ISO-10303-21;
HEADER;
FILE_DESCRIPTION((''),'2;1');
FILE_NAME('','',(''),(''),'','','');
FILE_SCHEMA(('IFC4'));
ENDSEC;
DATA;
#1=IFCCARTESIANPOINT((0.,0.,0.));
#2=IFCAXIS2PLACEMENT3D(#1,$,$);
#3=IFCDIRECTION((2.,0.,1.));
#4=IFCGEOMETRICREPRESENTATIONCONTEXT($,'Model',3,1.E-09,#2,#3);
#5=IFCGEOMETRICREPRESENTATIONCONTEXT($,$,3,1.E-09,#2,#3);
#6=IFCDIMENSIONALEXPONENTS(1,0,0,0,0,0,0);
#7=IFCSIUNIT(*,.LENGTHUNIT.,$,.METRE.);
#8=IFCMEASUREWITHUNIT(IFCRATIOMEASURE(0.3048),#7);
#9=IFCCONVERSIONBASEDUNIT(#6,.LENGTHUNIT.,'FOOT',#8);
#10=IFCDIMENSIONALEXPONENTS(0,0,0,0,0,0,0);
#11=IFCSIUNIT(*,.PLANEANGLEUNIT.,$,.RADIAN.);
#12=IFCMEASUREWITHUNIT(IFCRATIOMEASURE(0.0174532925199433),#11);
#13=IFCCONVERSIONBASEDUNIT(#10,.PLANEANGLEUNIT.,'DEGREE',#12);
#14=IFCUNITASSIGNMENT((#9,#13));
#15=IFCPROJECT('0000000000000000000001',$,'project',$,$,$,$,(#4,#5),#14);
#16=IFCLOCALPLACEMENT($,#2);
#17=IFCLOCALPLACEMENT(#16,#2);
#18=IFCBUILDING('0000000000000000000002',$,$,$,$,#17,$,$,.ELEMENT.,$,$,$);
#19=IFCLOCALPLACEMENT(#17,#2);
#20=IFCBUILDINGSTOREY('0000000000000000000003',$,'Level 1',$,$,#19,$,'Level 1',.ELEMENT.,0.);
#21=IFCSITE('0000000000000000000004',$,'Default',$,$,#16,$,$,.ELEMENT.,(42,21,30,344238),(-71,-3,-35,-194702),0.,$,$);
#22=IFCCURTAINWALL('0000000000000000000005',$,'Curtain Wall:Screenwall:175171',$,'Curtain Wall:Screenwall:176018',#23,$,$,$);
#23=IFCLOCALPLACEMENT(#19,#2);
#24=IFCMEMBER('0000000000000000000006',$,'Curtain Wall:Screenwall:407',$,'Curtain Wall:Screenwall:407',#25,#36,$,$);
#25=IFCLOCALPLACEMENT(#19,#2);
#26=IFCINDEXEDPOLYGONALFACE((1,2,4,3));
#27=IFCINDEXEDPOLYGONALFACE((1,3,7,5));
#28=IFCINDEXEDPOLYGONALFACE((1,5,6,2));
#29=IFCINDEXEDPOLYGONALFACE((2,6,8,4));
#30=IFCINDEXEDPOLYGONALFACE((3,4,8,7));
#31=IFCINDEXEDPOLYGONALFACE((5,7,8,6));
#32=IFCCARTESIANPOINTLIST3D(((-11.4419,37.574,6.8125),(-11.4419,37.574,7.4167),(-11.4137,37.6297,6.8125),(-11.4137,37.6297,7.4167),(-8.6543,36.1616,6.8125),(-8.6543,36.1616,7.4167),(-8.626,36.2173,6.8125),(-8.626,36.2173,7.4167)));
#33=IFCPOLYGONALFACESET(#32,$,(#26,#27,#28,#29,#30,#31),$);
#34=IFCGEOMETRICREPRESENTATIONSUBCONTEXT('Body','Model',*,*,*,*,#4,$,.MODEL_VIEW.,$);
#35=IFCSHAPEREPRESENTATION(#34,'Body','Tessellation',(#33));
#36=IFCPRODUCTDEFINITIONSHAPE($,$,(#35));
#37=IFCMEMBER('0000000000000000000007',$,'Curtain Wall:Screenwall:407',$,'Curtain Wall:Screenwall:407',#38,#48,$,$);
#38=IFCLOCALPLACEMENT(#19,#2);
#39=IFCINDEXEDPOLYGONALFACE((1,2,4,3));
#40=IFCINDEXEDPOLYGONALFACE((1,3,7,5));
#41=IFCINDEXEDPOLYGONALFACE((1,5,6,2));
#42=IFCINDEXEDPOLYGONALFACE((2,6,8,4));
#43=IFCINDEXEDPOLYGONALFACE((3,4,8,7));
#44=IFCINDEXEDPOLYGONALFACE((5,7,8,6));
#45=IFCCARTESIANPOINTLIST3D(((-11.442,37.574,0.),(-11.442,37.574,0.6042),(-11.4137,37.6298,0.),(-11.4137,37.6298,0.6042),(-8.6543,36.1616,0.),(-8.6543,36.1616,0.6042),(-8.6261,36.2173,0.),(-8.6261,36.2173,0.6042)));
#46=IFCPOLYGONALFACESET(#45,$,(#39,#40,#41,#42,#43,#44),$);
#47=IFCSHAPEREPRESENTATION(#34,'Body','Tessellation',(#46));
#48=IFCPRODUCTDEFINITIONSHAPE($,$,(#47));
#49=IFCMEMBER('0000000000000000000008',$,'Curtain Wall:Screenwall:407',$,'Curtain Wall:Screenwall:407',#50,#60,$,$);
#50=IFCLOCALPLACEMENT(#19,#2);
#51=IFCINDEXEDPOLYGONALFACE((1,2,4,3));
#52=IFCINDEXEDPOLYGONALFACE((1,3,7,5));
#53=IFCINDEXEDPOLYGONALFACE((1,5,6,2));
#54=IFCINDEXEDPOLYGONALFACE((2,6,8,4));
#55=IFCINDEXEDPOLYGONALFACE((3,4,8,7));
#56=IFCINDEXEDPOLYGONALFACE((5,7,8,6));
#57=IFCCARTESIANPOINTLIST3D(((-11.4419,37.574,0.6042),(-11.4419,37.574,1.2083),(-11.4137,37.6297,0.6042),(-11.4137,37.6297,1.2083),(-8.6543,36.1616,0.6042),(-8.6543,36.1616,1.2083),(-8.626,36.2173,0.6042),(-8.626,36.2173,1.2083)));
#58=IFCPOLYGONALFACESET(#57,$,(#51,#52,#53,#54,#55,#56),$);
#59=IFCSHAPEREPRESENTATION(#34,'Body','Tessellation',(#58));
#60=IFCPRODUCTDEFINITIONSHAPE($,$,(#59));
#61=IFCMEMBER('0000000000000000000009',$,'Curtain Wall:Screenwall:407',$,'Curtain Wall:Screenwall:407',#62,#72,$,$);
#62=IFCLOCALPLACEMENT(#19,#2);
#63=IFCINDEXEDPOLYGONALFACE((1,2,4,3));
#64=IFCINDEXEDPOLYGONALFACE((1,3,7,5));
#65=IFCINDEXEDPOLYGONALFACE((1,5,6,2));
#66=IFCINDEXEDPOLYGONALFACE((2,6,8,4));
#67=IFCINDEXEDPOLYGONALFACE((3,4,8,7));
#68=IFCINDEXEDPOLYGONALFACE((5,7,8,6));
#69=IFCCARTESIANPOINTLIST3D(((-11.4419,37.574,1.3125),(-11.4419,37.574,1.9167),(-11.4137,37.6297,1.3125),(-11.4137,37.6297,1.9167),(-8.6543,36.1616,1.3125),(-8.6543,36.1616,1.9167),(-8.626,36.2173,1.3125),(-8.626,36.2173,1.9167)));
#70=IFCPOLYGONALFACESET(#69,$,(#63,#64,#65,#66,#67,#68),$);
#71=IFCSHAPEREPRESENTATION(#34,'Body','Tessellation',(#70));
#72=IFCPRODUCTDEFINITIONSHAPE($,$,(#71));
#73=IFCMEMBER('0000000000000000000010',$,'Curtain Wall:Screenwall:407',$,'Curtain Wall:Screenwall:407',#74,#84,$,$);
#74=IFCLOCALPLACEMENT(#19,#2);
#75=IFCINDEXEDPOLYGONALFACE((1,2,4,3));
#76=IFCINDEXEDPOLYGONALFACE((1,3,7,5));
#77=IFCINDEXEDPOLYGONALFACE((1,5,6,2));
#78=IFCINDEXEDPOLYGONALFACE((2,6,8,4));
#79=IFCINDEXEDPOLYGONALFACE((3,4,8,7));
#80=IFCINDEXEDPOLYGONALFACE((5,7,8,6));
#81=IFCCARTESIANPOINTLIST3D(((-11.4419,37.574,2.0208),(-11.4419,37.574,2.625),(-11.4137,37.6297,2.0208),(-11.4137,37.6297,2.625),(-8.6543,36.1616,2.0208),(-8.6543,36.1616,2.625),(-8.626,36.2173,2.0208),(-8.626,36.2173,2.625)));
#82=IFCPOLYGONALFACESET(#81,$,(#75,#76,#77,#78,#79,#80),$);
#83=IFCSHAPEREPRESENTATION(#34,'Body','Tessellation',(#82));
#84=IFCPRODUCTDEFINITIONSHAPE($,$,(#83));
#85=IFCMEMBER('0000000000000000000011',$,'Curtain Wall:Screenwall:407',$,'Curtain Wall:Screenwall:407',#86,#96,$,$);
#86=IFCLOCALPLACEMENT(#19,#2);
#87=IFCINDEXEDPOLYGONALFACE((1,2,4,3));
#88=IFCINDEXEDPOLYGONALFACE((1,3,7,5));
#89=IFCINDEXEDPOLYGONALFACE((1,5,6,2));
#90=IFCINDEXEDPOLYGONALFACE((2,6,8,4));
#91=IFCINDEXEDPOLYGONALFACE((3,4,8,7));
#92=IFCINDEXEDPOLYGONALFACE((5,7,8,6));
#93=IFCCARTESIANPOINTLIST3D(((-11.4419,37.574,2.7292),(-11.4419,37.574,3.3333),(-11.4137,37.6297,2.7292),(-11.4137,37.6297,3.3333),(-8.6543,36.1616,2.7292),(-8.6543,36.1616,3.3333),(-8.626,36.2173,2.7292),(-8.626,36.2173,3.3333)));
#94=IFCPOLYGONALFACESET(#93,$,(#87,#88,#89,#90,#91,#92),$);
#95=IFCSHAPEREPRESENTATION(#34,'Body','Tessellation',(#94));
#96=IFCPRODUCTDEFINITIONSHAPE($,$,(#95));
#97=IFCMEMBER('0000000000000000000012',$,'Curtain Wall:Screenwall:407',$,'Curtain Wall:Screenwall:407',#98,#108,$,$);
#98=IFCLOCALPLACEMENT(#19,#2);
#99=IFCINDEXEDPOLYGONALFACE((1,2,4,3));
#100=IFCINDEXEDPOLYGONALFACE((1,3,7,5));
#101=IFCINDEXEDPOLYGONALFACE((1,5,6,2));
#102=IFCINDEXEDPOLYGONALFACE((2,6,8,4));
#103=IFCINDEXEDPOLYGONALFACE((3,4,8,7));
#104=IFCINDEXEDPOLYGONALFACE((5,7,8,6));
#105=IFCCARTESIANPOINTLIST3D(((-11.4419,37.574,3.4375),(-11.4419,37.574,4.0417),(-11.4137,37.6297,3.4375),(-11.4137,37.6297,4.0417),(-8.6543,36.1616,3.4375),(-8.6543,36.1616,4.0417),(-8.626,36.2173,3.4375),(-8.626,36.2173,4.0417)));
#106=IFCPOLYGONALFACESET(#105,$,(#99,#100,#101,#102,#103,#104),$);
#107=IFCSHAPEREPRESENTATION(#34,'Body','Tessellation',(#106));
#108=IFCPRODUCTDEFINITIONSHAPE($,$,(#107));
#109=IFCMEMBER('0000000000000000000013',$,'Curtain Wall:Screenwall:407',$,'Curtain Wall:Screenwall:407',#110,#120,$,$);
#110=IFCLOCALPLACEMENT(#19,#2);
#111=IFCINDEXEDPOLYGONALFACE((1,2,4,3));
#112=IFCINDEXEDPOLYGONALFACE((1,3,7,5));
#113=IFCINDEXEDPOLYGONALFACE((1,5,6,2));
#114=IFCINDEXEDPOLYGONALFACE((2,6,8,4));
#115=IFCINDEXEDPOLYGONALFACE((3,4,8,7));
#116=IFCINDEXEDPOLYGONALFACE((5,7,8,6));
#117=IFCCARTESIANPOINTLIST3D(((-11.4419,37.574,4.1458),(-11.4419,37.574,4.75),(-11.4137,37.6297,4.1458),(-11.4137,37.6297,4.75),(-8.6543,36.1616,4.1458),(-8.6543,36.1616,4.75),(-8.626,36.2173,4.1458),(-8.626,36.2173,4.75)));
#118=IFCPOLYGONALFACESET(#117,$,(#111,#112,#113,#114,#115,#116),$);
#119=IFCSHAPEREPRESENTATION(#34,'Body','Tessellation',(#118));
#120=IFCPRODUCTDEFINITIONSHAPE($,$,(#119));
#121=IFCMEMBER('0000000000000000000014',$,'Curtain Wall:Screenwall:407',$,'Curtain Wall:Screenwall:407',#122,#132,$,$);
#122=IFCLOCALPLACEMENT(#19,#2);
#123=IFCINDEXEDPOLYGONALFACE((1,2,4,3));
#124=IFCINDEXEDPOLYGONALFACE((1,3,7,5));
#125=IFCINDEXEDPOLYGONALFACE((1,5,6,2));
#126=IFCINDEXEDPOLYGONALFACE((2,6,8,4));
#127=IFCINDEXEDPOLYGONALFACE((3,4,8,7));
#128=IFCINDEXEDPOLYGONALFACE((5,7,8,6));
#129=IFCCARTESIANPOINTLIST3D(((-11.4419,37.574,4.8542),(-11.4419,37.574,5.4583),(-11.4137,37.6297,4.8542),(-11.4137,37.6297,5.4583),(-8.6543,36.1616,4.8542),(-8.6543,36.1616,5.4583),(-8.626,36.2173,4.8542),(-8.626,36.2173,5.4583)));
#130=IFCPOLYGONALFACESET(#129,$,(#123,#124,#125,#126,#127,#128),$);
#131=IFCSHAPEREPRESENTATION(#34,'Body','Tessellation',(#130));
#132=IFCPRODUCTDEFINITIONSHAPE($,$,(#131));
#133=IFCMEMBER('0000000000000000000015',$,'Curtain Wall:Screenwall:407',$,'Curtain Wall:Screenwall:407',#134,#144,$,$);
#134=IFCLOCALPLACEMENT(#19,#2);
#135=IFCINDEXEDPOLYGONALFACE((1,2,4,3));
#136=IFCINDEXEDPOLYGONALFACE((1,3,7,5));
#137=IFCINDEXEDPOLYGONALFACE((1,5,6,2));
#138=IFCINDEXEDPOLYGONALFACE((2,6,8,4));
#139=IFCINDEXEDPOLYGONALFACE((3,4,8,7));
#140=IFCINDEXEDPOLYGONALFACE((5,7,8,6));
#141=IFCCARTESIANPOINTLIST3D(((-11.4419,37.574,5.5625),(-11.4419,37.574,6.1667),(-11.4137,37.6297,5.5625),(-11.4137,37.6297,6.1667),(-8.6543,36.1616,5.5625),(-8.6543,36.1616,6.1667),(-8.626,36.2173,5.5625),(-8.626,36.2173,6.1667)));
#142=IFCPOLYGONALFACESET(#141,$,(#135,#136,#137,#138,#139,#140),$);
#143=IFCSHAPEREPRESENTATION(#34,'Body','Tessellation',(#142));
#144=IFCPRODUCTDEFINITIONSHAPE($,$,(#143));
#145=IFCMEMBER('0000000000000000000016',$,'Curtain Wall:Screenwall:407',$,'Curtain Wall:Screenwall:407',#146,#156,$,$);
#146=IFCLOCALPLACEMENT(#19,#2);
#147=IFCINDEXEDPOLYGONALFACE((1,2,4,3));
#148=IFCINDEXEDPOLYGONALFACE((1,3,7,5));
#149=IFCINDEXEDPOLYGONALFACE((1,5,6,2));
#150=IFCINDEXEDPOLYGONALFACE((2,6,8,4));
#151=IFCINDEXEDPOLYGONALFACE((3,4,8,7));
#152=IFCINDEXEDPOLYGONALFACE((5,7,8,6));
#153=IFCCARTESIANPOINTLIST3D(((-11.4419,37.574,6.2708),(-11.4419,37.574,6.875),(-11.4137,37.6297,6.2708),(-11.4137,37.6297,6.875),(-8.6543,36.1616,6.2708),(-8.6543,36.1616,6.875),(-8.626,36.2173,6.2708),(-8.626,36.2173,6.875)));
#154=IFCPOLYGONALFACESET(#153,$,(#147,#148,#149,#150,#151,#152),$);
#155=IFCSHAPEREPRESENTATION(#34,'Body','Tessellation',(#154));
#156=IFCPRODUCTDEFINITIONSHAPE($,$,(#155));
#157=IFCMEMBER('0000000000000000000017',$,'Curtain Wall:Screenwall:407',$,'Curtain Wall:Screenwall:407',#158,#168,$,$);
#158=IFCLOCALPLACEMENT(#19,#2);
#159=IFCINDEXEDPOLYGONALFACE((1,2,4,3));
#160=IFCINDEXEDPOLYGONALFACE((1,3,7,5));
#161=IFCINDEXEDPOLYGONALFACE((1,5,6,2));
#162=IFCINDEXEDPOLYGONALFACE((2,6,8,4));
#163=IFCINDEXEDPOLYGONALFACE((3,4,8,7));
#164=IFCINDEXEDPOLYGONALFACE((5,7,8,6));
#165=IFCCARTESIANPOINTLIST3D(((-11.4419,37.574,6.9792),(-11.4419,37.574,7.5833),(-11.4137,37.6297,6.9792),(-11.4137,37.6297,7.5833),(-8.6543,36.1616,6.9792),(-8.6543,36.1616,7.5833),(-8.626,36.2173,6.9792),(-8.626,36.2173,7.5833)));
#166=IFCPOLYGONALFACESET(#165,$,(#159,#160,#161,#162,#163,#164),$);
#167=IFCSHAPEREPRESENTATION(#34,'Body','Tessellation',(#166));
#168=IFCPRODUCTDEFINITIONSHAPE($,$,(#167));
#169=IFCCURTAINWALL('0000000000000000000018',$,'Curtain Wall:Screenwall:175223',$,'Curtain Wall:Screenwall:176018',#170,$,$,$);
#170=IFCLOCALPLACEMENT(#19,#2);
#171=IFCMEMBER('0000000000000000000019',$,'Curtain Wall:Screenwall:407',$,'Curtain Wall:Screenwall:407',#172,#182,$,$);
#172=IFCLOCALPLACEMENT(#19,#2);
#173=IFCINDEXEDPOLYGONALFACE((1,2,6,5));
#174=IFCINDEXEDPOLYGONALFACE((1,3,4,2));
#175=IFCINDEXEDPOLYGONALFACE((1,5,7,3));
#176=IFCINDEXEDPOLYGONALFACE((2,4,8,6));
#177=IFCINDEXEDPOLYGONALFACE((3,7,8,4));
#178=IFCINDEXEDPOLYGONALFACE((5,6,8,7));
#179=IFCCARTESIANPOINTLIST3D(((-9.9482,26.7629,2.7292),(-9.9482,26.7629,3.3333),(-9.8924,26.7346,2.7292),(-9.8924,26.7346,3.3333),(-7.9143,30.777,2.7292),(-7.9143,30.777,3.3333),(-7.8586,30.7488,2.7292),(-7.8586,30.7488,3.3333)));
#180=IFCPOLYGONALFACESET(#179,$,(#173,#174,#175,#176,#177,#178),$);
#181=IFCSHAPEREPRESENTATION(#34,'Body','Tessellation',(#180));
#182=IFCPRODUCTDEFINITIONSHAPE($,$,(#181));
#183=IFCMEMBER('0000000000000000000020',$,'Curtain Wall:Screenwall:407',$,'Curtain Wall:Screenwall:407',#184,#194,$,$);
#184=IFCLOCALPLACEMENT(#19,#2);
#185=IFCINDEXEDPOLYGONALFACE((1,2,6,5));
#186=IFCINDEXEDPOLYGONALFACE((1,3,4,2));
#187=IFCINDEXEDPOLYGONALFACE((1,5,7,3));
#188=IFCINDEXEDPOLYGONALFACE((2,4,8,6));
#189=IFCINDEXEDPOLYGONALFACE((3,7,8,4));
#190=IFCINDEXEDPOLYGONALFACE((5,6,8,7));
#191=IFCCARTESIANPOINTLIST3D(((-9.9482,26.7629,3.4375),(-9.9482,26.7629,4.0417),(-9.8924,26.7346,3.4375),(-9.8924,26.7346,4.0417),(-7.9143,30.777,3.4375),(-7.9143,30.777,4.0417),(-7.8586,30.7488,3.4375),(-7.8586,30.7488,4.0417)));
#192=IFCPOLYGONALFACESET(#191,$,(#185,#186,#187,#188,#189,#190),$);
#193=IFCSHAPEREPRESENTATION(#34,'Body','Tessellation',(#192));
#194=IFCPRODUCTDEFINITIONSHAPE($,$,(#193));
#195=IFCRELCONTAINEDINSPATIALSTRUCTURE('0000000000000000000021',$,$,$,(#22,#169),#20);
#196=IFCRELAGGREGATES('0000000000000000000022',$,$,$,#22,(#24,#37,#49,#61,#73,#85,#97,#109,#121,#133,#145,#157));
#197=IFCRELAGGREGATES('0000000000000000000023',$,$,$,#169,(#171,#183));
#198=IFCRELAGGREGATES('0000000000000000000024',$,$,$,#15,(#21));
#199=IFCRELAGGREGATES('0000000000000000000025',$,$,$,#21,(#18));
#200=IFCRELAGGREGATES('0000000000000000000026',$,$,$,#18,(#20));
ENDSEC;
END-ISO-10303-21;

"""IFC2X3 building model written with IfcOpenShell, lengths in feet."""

from ifc_helpers import new_model, entity, si_unit, converted_unit, direction, frame, frame_2d, origin, origin_2d_with_axis, place, context, subcontext, project, spatial, rectangle, extrude, element, aggregate, save


model = new_model("IFC2X3")

# Units and contexts
model_context = context("Model", 3, precision=1e-09, world=origin(), true_north=direction((2.0, 0.0, 1.0)))
context_of_model = context(None, 3, precision=1e-09, world=origin(), true_north=direction((2.0, 0.0, 1.0)))
body_context = subcontext(model_context, "Body", "Model", "MODEL_VIEW")
ifc_project = project(units=[converted_unit("LENGTHUNIT", "FOOT", entity("IfcRatioMeasure", 0.3048), si_unit("LENGTHUNIT", "METRE"), dimensions=[1, 0, 0, 0, 0, 0, 0]), converted_unit("PLANEANGLEUNIT", "DEGREE", entity("IfcRatioMeasure", 0.0174532925199433), si_unit("PLANEANGLEUNIT", "RADIAN"), dimensions=[0, 0, 0, 0, 0, 0, 0])], contexts=[model_context, context_of_model])

# Site, building, storey
site_placement = place(None, origin())
site = spatial("IfcSite", under=ifc_project, at=site_placement, Name="Default", CompositionType="ELEMENT", RefLatitude=(42, 21, 30, 344238), RefLongitude=(-71, -3, -35, -194702), RefElevation=0.0)
building_placement = place(site_placement, origin())
building = spatial("IfcBuilding", under=site, at=building_placement, CompositionType="ELEMENT")
storey_placement = place(building_placement, origin())
storey = spatial("IfcBuildingStorey", under=building, at=storey_placement, Name="Level 1", LongName="Level 1", CompositionType="ELEMENT", Elevation=0.0)

# Curtain walls, members
curtain_wall_1_placement = place(storey_placement, origin())
curtain_wall_1 = element("IfcCurtainWall", 1, at=curtain_wall_1_placement, inside=storey, Name="Curtain Wall:Screenwall:175171", ObjectType="Curtain Wall:Screenwall:176018")
member_1_placement = place(curtain_wall_1_placement, frame((-11.4419, 36.1616, 6.8125)))
member_1 = element("IfcMember", 2, at=member_1_placement, Name="Curtain Wall:Screenwall:407", ObjectType="Curtain Wall:Screenwall:407", context=body_context, shape_type="SweptSolid", body=[
    extrude(rectangle(XDim=3.1251, YDim=0.0625, at=frame_2d((0.0, 0.0), x_axis=(1.0, 0.0))), frame((1.408, 0.7341, 0.0), z_axis=(0.0, 0.0, 1.0), x_axis=(0.892034, -0.451968, 0.0)), (0.0, 0.0, 1.0), 0.6042),
])
member_2_placement = place(curtain_wall_1_placement, frame((-11.442, 36.1616, 0.0)))
member_2 = element("IfcMember", 3, at=member_2_placement, Name="Curtain Wall:Screenwall:407", ObjectType="Curtain Wall:Screenwall:407", context=body_context, shape_type="SweptSolid", body=[
    extrude(rectangle(XDim=3.1251, YDim=0.0625, at=frame_2d((0.0, 0.0), x_axis=(1.0, 0.0))), frame((1.408, 0.7341, 0.0), z_axis=(0.0, 0.0, 1.0), x_axis=(-0.892034, 0.451968, 0.0)), (0.0, 0.0, 1.0), 0.6042),
])
member_3_placement = place(curtain_wall_1_placement, frame((-11.4419, 36.1616, 0.6042)))
member_3 = element("IfcMember", 4, at=member_3_placement, Name="Curtain Wall:Screenwall:407", ObjectType="Curtain Wall:Screenwall:407", context=body_context, shape_type="SweptSolid", body=[
    extrude(rectangle(XDim=3.1251, YDim=0.0625, at=frame_2d((0.0, 0.0), x_axis=(1.0, 0.0))), frame((1.408, 0.7341, 0.0), z_axis=(0.0, 0.0, 1.0), x_axis=(0.892034, -0.451968, 0.0)), (0.0, 0.0, 1.0), 0.6042),
])
member_4_placement = place(curtain_wall_1_placement, frame((-11.4419, 36.1616, 1.3125)))
member_4 = element("IfcMember", 5, at=member_4_placement, Name="Curtain Wall:Screenwall:407", ObjectType="Curtain Wall:Screenwall:407", context=body_context, shape_type="SweptSolid", body=[
    extrude(rectangle(XDim=3.1251, YDim=0.0625, at=frame_2d((0.0, 0.0), x_axis=(1.0, 0.0))), frame((1.408, 0.7341, 0.0), z_axis=(0.0, 0.0, 1.0), x_axis=(0.892034, -0.451968, 0.0)), (0.0, 0.0, 1.0), 0.6042),
])
member_5_placement = place(curtain_wall_1_placement, frame((-11.4419, 36.1616, 2.0208)))
member_5 = element("IfcMember", 6, at=member_5_placement, Name="Curtain Wall:Screenwall:407", ObjectType="Curtain Wall:Screenwall:407", context=body_context, shape_type="SweptSolid", body=[
    extrude(rectangle(XDim=3.1251, YDim=0.0625, at=frame_2d((0.0, 0.0), x_axis=(1.0, 0.0))), frame((1.408, 0.7341, 0.0), z_axis=(0.0, 0.0, 1.0), x_axis=(0.892034, -0.451968, 0.0)), (0.0, 0.0, 1.0), 0.6042),
])
member_6_placement = place(curtain_wall_1_placement, frame((-11.4419, 36.1616, 2.7292)))
member_6 = element("IfcMember", 7, at=member_6_placement, Name="Curtain Wall:Screenwall:407", ObjectType="Curtain Wall:Screenwall:407", context=body_context, shape_type="SweptSolid", body=[
    extrude(rectangle(XDim=3.1251, YDim=0.0625, at=frame_2d((0.0, 0.0), x_axis=(1.0, 0.0))), frame((1.408, 0.7341, 0.0), z_axis=(0.0, 0.0, 1.0), x_axis=(0.892034, -0.451968, 0.0)), (0.0, 0.0, 1.0), 0.6042),
])
member_7_placement = place(curtain_wall_1_placement, frame((-11.4419, 36.1616, 3.4375)))
member_7 = element("IfcMember", 8, at=member_7_placement, Name="Curtain Wall:Screenwall:407", ObjectType="Curtain Wall:Screenwall:407", context=body_context, shape_type="SweptSolid", body=[
    extrude(rectangle(XDim=3.1251, YDim=0.0625, at=frame_2d((0.0, 0.0), x_axis=(1.0, 0.0))), frame((1.408, 0.7341, 0.0), z_axis=(0.0, 0.0, 1.0), x_axis=(0.892034, -0.451968, 0.0)), (0.0, 0.0, 1.0), 0.6042),
])
member_8_placement = place(curtain_wall_1_placement, frame((-11.4419, 36.1616, 4.1458)))
member_8 = element("IfcMember", 9, at=member_8_placement, Name="Curtain Wall:Screenwall:407", ObjectType="Curtain Wall:Screenwall:407", context=body_context, shape_type="SweptSolid", body=[
    extrude(rectangle(XDim=3.1251, YDim=0.0625, at=frame_2d((0.0, 0.0), x_axis=(1.0, 0.0))), frame((1.408, 0.7341, 0.0), z_axis=(0.0, 0.0, 1.0), x_axis=(0.892034, -0.451968, 0.0)), (0.0, 0.0, 1.0), 0.6042),
])
member_9_placement = place(curtain_wall_1_placement, frame((-11.4419, 36.1616, 4.8542)))
member_9 = element("IfcMember", 10, at=member_9_placement, Name="Curtain Wall:Screenwall:407", ObjectType="Curtain Wall:Screenwall:407", context=body_context, shape_type="SweptSolid", body=[
    extrude(rectangle(XDim=3.1251, YDim=0.0625, at=frame_2d((0.0, 0.0), x_axis=(1.0, 0.0))), frame((1.408, 0.7341, 0.0), z_axis=(0.0, 0.0, 1.0), x_axis=(0.892034, -0.451968, 0.0)), (0.0, 0.0, 1.0), 0.6042),
])
member_10_placement = place(curtain_wall_1_placement, frame((-11.4419, 36.1616, 5.5625)))
member_10 = element("IfcMember", 11, at=member_10_placement, Name="Curtain Wall:Screenwall:407", ObjectType="Curtain Wall:Screenwall:407", context=body_context, shape_type="SweptSolid", body=[
    extrude(rectangle(XDim=3.1251, YDim=0.0625, at=frame_2d((0.0, 0.0), x_axis=(1.0, 0.0))), frame((1.408, 0.7341, 0.0), z_axis=(0.0, 0.0, 1.0), x_axis=(0.892034, -0.451968, 0.0)), (0.0, 0.0, 1.0), 0.6042),
])
member_11_placement = place(curtain_wall_1_placement, frame((-11.4419, 36.1616, 6.2708)))
member_11 = element("IfcMember", 12, at=member_11_placement, Name="Curtain Wall:Screenwall:407", ObjectType="Curtain Wall:Screenwall:407", context=body_context, shape_type="SweptSolid", body=[
    extrude(rectangle(XDim=3.1251, YDim=0.0625, at=frame_2d((0.0, 0.0), x_axis=(1.0, 0.0))), frame((1.408, 0.7341, 0.0), z_axis=(0.0, 0.0, 1.0), x_axis=(0.892034, -0.451968, 0.0)), (0.0, 0.0, 1.0), 0.6042),
])
member_12_placement = place(curtain_wall_1_placement, frame((-11.4419, 36.1616, 6.9792)))
member_12 = element("IfcMember", 13, at=member_12_placement, Name="Curtain Wall:Screenwall:407", ObjectType="Curtain Wall:Screenwall:407", context=body_context, shape_type="SweptSolid", body=[
    extrude(rectangle(XDim=3.1251, YDim=0.0625, at=frame_2d((0.0, 0.0), x_axis=(1.0, 0.0))), frame((1.408, 0.7341, 0.0), z_axis=(0.0, 0.0, 1.0), x_axis=(0.892034, -0.451968, 0.0)), (0.0, 0.0, 1.0), 0.6042),
])
aggregate(curtain_wall_1, [member_1, member_2, member_3, member_4, member_5, member_6, member_7, member_8, member_9, member_10, member_11, member_12])
curtain_wall_2_placement = place(storey_placement, origin())
curtain_wall_2 = element("IfcCurtainWall", 14, at=curtain_wall_2_placement, inside=storey, Name="Curtain Wall:Screenwall:175223", ObjectType="Curtain Wall:Screenwall:176018")
member_13_placement = place(curtain_wall_2_placement, frame((-9.9482, 26.7346, 2.7292)))
member_13 = element("IfcMember", 15, at=member_13_placement, Name="Curtain Wall:Screenwall:407", ObjectType="Curtain Wall:Screenwall:407", context=body_context, shape_type="SweptSolid", body=[
    extrude(rectangle(XDim=4.5, YDim=0.0625, at=origin_2d_with_axis()), frame((1.0448, 2.0212, 0.0), z_axis=(0.0, 0.0, 1.0), x_axis=(-0.451968, -0.892034, 0.0)), (0.0, 0.0, 1.0), 0.6042),
])
member_14_placement = place(curtain_wall_2_placement, frame((-9.9482, 26.7346, 3.4375)))
member_14 = element("IfcMember", 16, at=member_14_placement, Name="Curtain Wall:Screenwall:407", ObjectType="Curtain Wall:Screenwall:407", context=body_context, shape_type="SweptSolid", body=[
    extrude(rectangle(XDim=4.5, YDim=0.0625, at=origin_2d_with_axis()), frame((1.0448, 2.0212, 0.0), z_axis=(0.0, 0.0, 1.0), x_axis=(-0.451968, -0.892034, 0.0)), (0.0, 0.0, 1.0), 0.6042),
])
aggregate(curtain_wall_2, [member_13, member_14])

save(model, "model.ifc")
